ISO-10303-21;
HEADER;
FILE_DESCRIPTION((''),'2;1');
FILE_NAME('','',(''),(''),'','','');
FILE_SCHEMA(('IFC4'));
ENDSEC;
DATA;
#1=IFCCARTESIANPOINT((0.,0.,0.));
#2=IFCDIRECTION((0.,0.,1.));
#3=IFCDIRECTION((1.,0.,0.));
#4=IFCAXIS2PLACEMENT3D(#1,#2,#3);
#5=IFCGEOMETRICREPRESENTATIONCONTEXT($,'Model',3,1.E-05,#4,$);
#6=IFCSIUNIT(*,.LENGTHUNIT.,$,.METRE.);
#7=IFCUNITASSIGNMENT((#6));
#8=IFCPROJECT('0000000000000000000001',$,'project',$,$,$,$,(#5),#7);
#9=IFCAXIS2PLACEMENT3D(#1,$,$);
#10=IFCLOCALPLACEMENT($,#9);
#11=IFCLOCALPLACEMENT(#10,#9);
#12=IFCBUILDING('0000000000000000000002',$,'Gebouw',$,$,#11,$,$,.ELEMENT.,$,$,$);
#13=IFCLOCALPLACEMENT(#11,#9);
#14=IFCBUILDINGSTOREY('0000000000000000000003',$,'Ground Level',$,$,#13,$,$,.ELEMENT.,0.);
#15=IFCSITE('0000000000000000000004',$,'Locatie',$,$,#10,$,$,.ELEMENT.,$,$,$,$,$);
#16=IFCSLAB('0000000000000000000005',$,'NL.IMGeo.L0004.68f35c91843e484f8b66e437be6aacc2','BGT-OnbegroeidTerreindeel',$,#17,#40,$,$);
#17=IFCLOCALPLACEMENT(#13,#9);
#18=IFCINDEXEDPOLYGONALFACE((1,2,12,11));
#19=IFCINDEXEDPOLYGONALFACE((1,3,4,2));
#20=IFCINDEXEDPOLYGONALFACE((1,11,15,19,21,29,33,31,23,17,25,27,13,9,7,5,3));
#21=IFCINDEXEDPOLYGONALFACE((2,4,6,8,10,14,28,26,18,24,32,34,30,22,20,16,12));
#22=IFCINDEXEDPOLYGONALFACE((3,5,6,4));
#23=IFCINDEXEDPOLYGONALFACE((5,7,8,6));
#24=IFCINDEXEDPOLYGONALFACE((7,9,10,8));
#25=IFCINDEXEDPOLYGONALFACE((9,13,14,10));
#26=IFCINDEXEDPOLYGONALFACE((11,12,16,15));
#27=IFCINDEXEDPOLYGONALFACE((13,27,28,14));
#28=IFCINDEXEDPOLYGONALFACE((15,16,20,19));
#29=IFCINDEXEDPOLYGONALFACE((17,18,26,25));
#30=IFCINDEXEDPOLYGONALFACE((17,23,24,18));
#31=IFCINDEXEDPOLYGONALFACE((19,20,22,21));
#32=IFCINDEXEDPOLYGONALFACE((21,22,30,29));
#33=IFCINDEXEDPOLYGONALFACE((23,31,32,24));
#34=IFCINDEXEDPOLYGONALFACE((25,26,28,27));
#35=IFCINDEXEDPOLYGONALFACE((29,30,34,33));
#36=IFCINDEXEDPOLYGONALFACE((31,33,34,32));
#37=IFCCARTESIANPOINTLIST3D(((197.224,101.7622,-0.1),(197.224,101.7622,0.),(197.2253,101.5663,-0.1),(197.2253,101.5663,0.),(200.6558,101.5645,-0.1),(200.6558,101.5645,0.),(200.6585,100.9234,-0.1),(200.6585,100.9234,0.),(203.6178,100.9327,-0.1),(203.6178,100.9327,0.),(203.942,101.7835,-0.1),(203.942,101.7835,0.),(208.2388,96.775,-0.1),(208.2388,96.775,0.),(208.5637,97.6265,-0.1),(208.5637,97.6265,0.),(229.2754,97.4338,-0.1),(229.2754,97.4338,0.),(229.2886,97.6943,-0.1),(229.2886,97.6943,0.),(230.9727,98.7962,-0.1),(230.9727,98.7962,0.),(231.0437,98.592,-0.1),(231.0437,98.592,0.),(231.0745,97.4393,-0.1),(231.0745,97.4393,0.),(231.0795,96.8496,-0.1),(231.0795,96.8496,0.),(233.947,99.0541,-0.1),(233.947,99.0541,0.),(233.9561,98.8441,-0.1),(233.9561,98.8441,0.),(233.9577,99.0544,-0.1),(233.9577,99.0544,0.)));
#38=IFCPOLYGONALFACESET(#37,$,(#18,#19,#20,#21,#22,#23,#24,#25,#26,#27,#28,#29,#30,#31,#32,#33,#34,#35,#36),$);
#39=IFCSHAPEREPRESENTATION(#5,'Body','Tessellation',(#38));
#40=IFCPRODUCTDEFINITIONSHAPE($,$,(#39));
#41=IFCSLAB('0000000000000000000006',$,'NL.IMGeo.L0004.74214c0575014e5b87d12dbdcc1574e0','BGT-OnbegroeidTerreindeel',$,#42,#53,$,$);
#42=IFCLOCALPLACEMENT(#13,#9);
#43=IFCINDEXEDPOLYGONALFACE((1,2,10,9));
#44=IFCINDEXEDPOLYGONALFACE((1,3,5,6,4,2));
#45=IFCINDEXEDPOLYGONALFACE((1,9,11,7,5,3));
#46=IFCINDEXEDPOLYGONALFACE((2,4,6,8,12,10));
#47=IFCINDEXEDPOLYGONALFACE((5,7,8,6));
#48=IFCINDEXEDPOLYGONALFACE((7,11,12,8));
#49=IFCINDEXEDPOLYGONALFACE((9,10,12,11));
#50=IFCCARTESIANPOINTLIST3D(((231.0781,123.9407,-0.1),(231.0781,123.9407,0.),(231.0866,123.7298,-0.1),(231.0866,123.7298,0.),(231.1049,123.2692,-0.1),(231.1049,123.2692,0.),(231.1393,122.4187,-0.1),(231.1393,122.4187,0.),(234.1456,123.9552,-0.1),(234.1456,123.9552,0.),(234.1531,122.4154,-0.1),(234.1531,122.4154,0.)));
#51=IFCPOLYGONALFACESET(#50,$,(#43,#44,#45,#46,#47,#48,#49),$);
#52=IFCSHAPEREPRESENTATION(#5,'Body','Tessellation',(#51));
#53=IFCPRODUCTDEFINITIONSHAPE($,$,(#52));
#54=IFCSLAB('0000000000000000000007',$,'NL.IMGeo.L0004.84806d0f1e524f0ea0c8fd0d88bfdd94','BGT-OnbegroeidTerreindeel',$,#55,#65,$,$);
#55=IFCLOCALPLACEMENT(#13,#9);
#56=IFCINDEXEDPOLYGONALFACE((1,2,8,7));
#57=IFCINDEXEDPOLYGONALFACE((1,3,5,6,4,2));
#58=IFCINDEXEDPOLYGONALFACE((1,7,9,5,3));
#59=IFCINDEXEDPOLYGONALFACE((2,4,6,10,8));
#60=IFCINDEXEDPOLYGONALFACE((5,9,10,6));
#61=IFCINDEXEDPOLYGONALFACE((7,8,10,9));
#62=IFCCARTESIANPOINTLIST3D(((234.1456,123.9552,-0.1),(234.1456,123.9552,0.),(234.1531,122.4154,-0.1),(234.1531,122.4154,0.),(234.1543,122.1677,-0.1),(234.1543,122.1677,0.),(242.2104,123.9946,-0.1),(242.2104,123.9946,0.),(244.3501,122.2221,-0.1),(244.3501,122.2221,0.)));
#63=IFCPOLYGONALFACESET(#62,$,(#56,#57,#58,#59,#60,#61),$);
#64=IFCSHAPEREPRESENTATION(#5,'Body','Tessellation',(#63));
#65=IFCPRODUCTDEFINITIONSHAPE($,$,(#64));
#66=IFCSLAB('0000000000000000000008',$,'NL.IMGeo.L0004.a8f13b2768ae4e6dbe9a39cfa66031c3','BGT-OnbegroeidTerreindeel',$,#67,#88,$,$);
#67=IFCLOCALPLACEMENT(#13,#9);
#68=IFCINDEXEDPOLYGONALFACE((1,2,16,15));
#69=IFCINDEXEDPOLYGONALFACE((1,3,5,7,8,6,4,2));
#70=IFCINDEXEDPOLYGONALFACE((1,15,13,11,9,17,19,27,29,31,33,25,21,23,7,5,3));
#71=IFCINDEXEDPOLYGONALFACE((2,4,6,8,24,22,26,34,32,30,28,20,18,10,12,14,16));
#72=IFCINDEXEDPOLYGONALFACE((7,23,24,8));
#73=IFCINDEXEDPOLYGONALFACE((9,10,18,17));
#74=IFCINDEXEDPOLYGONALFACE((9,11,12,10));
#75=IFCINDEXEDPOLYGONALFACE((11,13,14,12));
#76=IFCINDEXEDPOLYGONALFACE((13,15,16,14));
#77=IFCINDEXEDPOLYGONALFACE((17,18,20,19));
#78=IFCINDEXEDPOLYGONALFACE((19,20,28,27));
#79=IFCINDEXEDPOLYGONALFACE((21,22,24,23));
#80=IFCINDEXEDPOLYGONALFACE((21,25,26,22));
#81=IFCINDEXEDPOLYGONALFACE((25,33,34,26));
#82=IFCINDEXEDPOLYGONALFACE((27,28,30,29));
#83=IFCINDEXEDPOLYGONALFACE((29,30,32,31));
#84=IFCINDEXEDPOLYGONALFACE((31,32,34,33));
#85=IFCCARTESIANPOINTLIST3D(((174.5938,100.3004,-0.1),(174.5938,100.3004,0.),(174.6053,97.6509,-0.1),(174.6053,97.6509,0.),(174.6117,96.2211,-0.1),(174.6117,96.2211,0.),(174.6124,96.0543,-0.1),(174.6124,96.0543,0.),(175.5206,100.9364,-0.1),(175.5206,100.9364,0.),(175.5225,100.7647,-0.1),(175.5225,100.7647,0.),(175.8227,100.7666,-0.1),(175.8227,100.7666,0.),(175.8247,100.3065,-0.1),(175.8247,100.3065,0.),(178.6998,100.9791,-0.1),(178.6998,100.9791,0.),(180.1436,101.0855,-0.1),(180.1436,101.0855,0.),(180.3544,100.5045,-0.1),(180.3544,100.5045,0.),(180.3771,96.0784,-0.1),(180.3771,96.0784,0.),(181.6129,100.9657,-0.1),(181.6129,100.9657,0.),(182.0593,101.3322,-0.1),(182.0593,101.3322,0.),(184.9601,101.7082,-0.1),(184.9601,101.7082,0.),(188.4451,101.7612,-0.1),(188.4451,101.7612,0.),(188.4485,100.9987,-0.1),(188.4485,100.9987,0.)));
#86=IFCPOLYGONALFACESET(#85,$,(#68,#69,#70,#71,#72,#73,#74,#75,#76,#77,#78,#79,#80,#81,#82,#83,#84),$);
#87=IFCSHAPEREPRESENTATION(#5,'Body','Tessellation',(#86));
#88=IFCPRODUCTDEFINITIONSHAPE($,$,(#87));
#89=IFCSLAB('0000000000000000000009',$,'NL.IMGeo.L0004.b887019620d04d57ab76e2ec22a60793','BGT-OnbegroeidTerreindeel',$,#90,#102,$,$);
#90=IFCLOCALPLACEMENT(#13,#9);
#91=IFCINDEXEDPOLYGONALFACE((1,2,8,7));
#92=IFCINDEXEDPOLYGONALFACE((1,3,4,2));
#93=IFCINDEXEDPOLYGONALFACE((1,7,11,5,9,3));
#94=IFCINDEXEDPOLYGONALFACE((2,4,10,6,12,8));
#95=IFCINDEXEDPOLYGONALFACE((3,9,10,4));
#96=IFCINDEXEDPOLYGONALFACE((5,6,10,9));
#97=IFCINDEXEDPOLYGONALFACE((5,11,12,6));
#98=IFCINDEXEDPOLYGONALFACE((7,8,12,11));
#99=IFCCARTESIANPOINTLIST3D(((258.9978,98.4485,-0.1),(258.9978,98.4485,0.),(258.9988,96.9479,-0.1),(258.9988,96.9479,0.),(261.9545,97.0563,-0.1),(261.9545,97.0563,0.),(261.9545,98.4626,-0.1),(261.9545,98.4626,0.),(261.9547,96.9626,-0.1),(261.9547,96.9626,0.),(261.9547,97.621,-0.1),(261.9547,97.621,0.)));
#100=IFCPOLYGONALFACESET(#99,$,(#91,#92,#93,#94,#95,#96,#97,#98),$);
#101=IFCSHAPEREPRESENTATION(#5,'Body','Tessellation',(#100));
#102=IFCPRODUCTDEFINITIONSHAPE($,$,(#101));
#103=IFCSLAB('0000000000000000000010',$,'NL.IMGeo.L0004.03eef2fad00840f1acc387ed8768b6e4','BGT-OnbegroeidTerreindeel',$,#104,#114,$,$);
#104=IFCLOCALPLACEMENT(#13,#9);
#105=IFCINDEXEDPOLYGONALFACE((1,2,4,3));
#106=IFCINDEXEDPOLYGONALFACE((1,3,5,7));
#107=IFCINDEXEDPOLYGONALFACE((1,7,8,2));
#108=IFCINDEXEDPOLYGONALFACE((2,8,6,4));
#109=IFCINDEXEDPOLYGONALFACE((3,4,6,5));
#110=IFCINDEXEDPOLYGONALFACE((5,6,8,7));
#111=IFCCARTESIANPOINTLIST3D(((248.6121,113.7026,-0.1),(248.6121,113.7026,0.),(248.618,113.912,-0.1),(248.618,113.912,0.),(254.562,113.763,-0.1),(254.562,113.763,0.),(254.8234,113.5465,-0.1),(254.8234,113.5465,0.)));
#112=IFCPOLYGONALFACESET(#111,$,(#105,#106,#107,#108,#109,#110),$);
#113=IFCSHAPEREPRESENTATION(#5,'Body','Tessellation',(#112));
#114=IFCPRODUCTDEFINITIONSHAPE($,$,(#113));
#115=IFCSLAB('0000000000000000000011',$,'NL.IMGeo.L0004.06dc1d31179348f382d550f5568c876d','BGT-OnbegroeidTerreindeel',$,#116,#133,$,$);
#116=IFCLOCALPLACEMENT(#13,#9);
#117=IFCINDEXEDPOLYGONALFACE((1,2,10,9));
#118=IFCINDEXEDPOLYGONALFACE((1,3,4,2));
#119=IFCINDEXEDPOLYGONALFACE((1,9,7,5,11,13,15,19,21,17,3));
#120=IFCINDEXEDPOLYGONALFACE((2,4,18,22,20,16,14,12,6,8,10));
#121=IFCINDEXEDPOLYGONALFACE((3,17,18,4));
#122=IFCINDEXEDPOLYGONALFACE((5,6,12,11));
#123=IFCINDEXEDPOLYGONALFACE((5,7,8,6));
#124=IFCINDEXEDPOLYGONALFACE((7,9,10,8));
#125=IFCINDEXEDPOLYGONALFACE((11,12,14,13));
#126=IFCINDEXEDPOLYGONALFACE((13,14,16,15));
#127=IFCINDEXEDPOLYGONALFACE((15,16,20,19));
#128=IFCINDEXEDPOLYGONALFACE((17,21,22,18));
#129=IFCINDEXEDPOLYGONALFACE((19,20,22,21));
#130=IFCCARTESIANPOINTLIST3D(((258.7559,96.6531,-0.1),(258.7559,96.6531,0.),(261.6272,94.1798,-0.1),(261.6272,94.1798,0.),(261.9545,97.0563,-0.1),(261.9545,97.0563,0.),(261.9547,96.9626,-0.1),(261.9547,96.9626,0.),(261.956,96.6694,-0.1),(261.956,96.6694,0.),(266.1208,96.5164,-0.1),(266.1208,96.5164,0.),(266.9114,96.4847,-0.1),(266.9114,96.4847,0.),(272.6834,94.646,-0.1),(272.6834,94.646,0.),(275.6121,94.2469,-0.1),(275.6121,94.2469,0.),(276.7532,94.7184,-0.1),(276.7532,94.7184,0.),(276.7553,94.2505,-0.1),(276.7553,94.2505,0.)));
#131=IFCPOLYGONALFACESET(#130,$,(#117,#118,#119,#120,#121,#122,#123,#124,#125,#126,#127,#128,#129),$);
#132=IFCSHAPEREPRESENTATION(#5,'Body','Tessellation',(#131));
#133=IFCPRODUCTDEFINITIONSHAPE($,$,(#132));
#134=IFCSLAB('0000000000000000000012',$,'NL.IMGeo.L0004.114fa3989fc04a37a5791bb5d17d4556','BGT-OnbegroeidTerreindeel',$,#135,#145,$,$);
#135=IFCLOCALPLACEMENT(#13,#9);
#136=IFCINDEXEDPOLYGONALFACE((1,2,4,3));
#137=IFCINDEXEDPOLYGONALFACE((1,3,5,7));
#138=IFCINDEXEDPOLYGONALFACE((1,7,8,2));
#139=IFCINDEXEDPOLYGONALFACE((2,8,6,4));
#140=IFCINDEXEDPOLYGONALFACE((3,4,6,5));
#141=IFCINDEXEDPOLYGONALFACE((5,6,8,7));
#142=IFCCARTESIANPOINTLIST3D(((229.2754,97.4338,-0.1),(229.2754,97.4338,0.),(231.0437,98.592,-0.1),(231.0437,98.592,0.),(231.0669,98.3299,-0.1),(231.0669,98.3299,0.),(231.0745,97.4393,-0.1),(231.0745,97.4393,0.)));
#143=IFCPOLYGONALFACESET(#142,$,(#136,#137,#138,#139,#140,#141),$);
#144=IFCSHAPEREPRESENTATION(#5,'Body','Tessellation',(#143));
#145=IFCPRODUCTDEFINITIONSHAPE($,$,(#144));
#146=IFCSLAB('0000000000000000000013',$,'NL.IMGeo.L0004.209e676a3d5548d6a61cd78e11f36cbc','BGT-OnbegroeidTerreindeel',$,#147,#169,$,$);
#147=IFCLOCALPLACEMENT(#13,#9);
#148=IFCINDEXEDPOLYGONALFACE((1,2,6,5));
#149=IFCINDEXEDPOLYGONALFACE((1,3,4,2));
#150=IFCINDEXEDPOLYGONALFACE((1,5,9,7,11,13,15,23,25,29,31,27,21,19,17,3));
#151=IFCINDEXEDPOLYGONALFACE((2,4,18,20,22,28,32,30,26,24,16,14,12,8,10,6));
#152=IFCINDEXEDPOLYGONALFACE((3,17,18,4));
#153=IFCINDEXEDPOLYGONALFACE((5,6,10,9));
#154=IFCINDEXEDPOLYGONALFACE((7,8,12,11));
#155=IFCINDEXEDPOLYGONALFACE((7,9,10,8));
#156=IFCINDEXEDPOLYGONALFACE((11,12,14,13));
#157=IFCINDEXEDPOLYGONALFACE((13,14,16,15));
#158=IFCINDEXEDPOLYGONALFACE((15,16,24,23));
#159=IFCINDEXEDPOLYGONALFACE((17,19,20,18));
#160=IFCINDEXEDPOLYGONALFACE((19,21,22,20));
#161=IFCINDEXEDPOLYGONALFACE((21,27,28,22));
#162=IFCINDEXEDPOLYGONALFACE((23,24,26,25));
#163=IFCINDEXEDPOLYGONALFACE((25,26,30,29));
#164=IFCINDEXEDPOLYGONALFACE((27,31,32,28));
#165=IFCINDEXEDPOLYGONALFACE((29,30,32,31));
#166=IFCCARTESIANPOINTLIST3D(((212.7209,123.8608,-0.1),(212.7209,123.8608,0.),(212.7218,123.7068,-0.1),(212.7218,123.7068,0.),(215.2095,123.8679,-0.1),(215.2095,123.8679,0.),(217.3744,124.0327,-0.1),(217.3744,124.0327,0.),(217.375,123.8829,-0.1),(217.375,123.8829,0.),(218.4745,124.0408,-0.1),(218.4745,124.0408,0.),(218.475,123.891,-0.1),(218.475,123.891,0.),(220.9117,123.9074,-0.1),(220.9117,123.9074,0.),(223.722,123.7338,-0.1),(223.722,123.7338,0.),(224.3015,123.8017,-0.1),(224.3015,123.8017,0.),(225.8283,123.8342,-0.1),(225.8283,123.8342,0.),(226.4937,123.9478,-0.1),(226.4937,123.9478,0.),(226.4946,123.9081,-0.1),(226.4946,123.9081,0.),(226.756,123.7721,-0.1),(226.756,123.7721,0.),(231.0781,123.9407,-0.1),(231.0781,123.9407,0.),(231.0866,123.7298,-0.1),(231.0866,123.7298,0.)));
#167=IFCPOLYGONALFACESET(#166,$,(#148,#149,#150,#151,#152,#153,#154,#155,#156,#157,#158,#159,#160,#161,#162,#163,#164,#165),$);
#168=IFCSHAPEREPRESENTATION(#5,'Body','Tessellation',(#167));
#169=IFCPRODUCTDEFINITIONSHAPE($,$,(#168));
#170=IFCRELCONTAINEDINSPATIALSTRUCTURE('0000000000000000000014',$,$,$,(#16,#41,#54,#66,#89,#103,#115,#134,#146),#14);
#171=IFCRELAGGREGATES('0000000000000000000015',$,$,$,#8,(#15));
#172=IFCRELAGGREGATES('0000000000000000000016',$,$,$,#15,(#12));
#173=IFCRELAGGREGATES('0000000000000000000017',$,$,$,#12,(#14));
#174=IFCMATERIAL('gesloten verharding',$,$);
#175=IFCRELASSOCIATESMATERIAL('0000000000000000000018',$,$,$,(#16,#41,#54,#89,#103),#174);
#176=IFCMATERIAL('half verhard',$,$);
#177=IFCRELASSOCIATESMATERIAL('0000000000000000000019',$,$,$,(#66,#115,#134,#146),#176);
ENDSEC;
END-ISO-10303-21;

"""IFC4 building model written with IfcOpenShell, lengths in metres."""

from ifc_helpers import new_model, si_unit, frame, origin, origin_with_axes, place, context, project, spatial, polyline, outline, extrude, material, element, save


model = new_model("IFC4")

# Units and contexts
model_context = context("Model", 3, precision=1e-05, world=origin_with_axes())
ifc_project = project(units=[si_unit("LENGTHUNIT", "METRE")], contexts=[model_context])

# Site, building, storey
site_placement = place(None, origin())
site = spatial("IfcSite", under=ifc_project, at=site_placement, Name="Locatie", CompositionType="ELEMENT")
building_placement = place(site_placement, origin())
building = spatial("IfcBuilding", under=site, at=building_placement, Name="Gebouw", CompositionType="ELEMENT")
storey_placement = place(building_placement, origin())
storey = spatial("IfcBuildingStorey", under=building, at=storey_placement, Name="Ground Level", CompositionType="ELEMENT", Elevation=0.0)

# Slabs
ifc_material_1 = material(Name="gesloten verharding")
slab_1_placement = place(storey_placement, origin())
element("IfcSlab", 1, at=slab_1_placement, inside=storey, material=ifc_material_1, Name="NL.IMGeo.L0004.68f35c91843e484f8b66e437be6aacc2", Description="BGT-OnbegroeidTerreindeel", context=model_context, shape_type="SweptSolid", body=[
    extrude(outline(polyline([(208.2388, 96.775), (203.6178, 100.9327), (200.6585, 100.9234), (200.6558, 101.5645), (197.2253, 101.5663), (197.224, 101.7622), (203.942, 101.7835), (208.5637, 97.6265), (229.2886, 97.6943), (230.9727, 98.7962), (233.947, 99.0541), (233.9577, 99.0544), (233.9561, 98.8441), (231.0437, 98.592), (229.2754, 97.4338), (231.0745, 97.4393), (231.0795, 96.8496), (208.2388, 96.775)])), frame((0.0, 0.0, -0.1), z_axis=(0.0, 0.0, 1.0), x_axis=(1.0, 0.0, 0.0)), (0.0, 0.0, 1.0), 0.1),
])
slab_2_placement = place(storey_placement, origin())
element("IfcSlab", 2, at=slab_2_placement, inside=storey, material=ifc_material_1, Name="NL.IMGeo.L0004.74214c0575014e5b87d12dbdcc1574e0", Description="BGT-OnbegroeidTerreindeel", context=model_context, shape_type="SweptSolid", body=[
    extrude(outline(polyline([(231.1393, 122.4187), (231.1049, 123.2692), (231.0866, 123.7298), (231.0781, 123.9407), (234.1456, 123.9552), (234.1531, 122.4154), (231.1393, 122.4187)])), frame((0.0, 0.0, -0.1), z_axis=(0.0, 0.0, 1.0), x_axis=(1.0, 0.0, 0.0)), (0.0, 0.0, 1.0), 0.1),
])
slab_3_placement = place(storey_placement, origin())
element("IfcSlab", 3, at=slab_3_placement, inside=storey, material=ifc_material_1, Name="NL.IMGeo.L0004.84806d0f1e524f0ea0c8fd0d88bfdd94", Description="BGT-OnbegroeidTerreindeel", context=model_context, shape_type="SweptSolid", body=[
    extrude(outline(polyline([(234.1543, 122.1677), (234.1531, 122.4154), (234.1456, 123.9552), (242.2104, 123.9946), (244.3501, 122.2221), (234.1543, 122.1677)])), frame((0.0, 0.0, -0.1), z_axis=(0.0, 0.0, 1.0), x_axis=(1.0, 0.0, 0.0)), (0.0, 0.0, 1.0), 0.1),
])
ifc_material_2 = material(Name="half verhard")
slab_4_placement = place(storey_placement, origin())
element("IfcSlab", 4, at=slab_4_placement, inside=storey, material=ifc_material_2, Name="NL.IMGeo.L0004.a8f13b2768ae4e6dbe9a39cfa66031c3", Description="BGT-OnbegroeidTerreindeel", context=model_context, shape_type="SweptSolid", body=[
    extrude(outline(polyline([(175.8247, 100.3065), (175.8227, 100.7666), (175.5225, 100.7647), (175.5206, 100.9364), (178.6998, 100.9791), (180.1436, 101.0855), (182.0593, 101.3322), (184.9601, 101.7082), (188.4451, 101.7612), (188.4485, 100.9987), (181.6129, 100.9657), (180.3544, 100.5045), (180.3771, 96.0784), (174.6124, 96.0543), (174.6117, 96.2211), (174.6053, 97.6509), (174.5938, 100.3004), (175.8247, 100.3065)])), frame((0.0, 0.0, -0.1), z_axis=(0.0, 0.0, 1.0), x_axis=(1.0, 0.0, 0.0)), (0.0, 0.0, 1.0), 0.1),
])
slab_5_placement = place(storey_placement, origin())
element("IfcSlab", 5, at=slab_5_placement, inside=storey, material=ifc_material_1, Name="NL.IMGeo.L0004.b887019620d04d57ab76e2ec22a60793", Description="BGT-OnbegroeidTerreindeel", context=model_context, shape_type="SweptSolid", body=[
    extrude(outline(polyline([(258.9978, 98.4485), (261.9545, 98.4626), (261.9547, 97.621), (261.9545, 97.0563), (261.9547, 96.9626), (258.9988, 96.9479), (258.9978, 98.4485)])), frame((0.0, 0.0, -0.1), z_axis=(0.0, 0.0, 1.0), x_axis=(1.0, 0.0, 0.0)), (0.0, 0.0, 1.0), 0.1),
])
slab_6_placement = place(storey_placement, origin())
element("IfcSlab", 6, at=slab_6_placement, inside=storey, material=ifc_material_1, Name="NL.IMGeo.L0004.03eef2fad00840f1acc387ed8768b6e4", Description="BGT-OnbegroeidTerreindeel", context=model_context, shape_type="SweptSolid", body=[
    extrude(outline(polyline([(248.6121, 113.7026), (248.618, 113.912), (254.562, 113.763), (254.8234, 113.5465), (248.6121, 113.7026)])), frame((0.0, 0.0, -0.1), z_axis=(0.0, 0.0, 1.0), x_axis=(1.0, 0.0, 0.0)), (0.0, 0.0, 1.0), 0.1),
])
slab_7_placement = place(storey_placement, origin())
element("IfcSlab", 7, at=slab_7_placement, inside=storey, material=ifc_material_2, Name="NL.IMGeo.L0004.06dc1d31179348f382d550f5568c876d", Description="BGT-OnbegroeidTerreindeel", context=model_context, shape_type="SweptSolid", body=[
    extrude(outline(polyline([(261.956, 96.6694), (261.9547, 96.9626), (261.9545, 97.0563), (266.1208, 96.5164), (266.9114, 96.4847), (272.6834, 94.646), (276.7532, 94.7184), (276.7553, 94.2505), (275.6121, 94.2469), (261.6272, 94.1798), (258.7559, 96.6531), (261.956, 96.6694)])), frame((0.0, 0.0, -0.1), z_axis=(0.0, 0.0, 1.0), x_axis=(1.0, 0.0, 0.0)), (0.0, 0.0, 1.0), 0.1),
])
slab_8_placement = place(storey_placement, origin())
element("IfcSlab", 8, at=slab_8_placement, inside=storey, material=ifc_material_2, Name="NL.IMGeo.L0004.114fa3989fc04a37a5791bb5d17d4556", Description="BGT-OnbegroeidTerreindeel", context=model_context, shape_type="SweptSolid", body=[
    extrude(outline(polyline([(231.0437, 98.592), (231.0669, 98.3299), (231.0745, 97.4393), (229.2754, 97.4338), (231.0437, 98.592)])), frame((0.0, 0.0, -0.1), z_axis=(0.0, 0.0, 1.0), x_axis=(1.0, 0.0, 0.0)), (0.0, 0.0, 1.0), 0.1),
])
slab_9_placement = place(storey_placement, origin())
element("IfcSlab", 9, at=slab_9_placement, inside=storey, material=ifc_material_2, Name="NL.IMGeo.L0004.209e676a3d5548d6a61cd78e11f36cbc", Description="BGT-OnbegroeidTerreindeel", context=model_context, shape_type="SweptSolid", body=[
    extrude(outline(polyline([(212.7209, 123.8608), (215.2095, 123.8679), (217.375, 123.8829), (217.3744, 124.0327), (218.4745, 124.0408), (218.475, 123.891), (220.9117, 123.9074), (226.4937, 123.9478), (226.4946, 123.9081), (231.0781, 123.9407), (231.0866, 123.7298), (226.756, 123.7721), (225.8283, 123.8342), (224.3015, 123.8017), (223.722, 123.7338), (212.7218, 123.7068), (212.7209, 123.8608)])), frame((0.0, 0.0, -0.1), z_axis=(0.0, 0.0, 1.0), x_axis=(1.0, 0.0, 0.0)), (0.0, 0.0, 1.0), 0.1),
])

save(model, "model.ifc")
